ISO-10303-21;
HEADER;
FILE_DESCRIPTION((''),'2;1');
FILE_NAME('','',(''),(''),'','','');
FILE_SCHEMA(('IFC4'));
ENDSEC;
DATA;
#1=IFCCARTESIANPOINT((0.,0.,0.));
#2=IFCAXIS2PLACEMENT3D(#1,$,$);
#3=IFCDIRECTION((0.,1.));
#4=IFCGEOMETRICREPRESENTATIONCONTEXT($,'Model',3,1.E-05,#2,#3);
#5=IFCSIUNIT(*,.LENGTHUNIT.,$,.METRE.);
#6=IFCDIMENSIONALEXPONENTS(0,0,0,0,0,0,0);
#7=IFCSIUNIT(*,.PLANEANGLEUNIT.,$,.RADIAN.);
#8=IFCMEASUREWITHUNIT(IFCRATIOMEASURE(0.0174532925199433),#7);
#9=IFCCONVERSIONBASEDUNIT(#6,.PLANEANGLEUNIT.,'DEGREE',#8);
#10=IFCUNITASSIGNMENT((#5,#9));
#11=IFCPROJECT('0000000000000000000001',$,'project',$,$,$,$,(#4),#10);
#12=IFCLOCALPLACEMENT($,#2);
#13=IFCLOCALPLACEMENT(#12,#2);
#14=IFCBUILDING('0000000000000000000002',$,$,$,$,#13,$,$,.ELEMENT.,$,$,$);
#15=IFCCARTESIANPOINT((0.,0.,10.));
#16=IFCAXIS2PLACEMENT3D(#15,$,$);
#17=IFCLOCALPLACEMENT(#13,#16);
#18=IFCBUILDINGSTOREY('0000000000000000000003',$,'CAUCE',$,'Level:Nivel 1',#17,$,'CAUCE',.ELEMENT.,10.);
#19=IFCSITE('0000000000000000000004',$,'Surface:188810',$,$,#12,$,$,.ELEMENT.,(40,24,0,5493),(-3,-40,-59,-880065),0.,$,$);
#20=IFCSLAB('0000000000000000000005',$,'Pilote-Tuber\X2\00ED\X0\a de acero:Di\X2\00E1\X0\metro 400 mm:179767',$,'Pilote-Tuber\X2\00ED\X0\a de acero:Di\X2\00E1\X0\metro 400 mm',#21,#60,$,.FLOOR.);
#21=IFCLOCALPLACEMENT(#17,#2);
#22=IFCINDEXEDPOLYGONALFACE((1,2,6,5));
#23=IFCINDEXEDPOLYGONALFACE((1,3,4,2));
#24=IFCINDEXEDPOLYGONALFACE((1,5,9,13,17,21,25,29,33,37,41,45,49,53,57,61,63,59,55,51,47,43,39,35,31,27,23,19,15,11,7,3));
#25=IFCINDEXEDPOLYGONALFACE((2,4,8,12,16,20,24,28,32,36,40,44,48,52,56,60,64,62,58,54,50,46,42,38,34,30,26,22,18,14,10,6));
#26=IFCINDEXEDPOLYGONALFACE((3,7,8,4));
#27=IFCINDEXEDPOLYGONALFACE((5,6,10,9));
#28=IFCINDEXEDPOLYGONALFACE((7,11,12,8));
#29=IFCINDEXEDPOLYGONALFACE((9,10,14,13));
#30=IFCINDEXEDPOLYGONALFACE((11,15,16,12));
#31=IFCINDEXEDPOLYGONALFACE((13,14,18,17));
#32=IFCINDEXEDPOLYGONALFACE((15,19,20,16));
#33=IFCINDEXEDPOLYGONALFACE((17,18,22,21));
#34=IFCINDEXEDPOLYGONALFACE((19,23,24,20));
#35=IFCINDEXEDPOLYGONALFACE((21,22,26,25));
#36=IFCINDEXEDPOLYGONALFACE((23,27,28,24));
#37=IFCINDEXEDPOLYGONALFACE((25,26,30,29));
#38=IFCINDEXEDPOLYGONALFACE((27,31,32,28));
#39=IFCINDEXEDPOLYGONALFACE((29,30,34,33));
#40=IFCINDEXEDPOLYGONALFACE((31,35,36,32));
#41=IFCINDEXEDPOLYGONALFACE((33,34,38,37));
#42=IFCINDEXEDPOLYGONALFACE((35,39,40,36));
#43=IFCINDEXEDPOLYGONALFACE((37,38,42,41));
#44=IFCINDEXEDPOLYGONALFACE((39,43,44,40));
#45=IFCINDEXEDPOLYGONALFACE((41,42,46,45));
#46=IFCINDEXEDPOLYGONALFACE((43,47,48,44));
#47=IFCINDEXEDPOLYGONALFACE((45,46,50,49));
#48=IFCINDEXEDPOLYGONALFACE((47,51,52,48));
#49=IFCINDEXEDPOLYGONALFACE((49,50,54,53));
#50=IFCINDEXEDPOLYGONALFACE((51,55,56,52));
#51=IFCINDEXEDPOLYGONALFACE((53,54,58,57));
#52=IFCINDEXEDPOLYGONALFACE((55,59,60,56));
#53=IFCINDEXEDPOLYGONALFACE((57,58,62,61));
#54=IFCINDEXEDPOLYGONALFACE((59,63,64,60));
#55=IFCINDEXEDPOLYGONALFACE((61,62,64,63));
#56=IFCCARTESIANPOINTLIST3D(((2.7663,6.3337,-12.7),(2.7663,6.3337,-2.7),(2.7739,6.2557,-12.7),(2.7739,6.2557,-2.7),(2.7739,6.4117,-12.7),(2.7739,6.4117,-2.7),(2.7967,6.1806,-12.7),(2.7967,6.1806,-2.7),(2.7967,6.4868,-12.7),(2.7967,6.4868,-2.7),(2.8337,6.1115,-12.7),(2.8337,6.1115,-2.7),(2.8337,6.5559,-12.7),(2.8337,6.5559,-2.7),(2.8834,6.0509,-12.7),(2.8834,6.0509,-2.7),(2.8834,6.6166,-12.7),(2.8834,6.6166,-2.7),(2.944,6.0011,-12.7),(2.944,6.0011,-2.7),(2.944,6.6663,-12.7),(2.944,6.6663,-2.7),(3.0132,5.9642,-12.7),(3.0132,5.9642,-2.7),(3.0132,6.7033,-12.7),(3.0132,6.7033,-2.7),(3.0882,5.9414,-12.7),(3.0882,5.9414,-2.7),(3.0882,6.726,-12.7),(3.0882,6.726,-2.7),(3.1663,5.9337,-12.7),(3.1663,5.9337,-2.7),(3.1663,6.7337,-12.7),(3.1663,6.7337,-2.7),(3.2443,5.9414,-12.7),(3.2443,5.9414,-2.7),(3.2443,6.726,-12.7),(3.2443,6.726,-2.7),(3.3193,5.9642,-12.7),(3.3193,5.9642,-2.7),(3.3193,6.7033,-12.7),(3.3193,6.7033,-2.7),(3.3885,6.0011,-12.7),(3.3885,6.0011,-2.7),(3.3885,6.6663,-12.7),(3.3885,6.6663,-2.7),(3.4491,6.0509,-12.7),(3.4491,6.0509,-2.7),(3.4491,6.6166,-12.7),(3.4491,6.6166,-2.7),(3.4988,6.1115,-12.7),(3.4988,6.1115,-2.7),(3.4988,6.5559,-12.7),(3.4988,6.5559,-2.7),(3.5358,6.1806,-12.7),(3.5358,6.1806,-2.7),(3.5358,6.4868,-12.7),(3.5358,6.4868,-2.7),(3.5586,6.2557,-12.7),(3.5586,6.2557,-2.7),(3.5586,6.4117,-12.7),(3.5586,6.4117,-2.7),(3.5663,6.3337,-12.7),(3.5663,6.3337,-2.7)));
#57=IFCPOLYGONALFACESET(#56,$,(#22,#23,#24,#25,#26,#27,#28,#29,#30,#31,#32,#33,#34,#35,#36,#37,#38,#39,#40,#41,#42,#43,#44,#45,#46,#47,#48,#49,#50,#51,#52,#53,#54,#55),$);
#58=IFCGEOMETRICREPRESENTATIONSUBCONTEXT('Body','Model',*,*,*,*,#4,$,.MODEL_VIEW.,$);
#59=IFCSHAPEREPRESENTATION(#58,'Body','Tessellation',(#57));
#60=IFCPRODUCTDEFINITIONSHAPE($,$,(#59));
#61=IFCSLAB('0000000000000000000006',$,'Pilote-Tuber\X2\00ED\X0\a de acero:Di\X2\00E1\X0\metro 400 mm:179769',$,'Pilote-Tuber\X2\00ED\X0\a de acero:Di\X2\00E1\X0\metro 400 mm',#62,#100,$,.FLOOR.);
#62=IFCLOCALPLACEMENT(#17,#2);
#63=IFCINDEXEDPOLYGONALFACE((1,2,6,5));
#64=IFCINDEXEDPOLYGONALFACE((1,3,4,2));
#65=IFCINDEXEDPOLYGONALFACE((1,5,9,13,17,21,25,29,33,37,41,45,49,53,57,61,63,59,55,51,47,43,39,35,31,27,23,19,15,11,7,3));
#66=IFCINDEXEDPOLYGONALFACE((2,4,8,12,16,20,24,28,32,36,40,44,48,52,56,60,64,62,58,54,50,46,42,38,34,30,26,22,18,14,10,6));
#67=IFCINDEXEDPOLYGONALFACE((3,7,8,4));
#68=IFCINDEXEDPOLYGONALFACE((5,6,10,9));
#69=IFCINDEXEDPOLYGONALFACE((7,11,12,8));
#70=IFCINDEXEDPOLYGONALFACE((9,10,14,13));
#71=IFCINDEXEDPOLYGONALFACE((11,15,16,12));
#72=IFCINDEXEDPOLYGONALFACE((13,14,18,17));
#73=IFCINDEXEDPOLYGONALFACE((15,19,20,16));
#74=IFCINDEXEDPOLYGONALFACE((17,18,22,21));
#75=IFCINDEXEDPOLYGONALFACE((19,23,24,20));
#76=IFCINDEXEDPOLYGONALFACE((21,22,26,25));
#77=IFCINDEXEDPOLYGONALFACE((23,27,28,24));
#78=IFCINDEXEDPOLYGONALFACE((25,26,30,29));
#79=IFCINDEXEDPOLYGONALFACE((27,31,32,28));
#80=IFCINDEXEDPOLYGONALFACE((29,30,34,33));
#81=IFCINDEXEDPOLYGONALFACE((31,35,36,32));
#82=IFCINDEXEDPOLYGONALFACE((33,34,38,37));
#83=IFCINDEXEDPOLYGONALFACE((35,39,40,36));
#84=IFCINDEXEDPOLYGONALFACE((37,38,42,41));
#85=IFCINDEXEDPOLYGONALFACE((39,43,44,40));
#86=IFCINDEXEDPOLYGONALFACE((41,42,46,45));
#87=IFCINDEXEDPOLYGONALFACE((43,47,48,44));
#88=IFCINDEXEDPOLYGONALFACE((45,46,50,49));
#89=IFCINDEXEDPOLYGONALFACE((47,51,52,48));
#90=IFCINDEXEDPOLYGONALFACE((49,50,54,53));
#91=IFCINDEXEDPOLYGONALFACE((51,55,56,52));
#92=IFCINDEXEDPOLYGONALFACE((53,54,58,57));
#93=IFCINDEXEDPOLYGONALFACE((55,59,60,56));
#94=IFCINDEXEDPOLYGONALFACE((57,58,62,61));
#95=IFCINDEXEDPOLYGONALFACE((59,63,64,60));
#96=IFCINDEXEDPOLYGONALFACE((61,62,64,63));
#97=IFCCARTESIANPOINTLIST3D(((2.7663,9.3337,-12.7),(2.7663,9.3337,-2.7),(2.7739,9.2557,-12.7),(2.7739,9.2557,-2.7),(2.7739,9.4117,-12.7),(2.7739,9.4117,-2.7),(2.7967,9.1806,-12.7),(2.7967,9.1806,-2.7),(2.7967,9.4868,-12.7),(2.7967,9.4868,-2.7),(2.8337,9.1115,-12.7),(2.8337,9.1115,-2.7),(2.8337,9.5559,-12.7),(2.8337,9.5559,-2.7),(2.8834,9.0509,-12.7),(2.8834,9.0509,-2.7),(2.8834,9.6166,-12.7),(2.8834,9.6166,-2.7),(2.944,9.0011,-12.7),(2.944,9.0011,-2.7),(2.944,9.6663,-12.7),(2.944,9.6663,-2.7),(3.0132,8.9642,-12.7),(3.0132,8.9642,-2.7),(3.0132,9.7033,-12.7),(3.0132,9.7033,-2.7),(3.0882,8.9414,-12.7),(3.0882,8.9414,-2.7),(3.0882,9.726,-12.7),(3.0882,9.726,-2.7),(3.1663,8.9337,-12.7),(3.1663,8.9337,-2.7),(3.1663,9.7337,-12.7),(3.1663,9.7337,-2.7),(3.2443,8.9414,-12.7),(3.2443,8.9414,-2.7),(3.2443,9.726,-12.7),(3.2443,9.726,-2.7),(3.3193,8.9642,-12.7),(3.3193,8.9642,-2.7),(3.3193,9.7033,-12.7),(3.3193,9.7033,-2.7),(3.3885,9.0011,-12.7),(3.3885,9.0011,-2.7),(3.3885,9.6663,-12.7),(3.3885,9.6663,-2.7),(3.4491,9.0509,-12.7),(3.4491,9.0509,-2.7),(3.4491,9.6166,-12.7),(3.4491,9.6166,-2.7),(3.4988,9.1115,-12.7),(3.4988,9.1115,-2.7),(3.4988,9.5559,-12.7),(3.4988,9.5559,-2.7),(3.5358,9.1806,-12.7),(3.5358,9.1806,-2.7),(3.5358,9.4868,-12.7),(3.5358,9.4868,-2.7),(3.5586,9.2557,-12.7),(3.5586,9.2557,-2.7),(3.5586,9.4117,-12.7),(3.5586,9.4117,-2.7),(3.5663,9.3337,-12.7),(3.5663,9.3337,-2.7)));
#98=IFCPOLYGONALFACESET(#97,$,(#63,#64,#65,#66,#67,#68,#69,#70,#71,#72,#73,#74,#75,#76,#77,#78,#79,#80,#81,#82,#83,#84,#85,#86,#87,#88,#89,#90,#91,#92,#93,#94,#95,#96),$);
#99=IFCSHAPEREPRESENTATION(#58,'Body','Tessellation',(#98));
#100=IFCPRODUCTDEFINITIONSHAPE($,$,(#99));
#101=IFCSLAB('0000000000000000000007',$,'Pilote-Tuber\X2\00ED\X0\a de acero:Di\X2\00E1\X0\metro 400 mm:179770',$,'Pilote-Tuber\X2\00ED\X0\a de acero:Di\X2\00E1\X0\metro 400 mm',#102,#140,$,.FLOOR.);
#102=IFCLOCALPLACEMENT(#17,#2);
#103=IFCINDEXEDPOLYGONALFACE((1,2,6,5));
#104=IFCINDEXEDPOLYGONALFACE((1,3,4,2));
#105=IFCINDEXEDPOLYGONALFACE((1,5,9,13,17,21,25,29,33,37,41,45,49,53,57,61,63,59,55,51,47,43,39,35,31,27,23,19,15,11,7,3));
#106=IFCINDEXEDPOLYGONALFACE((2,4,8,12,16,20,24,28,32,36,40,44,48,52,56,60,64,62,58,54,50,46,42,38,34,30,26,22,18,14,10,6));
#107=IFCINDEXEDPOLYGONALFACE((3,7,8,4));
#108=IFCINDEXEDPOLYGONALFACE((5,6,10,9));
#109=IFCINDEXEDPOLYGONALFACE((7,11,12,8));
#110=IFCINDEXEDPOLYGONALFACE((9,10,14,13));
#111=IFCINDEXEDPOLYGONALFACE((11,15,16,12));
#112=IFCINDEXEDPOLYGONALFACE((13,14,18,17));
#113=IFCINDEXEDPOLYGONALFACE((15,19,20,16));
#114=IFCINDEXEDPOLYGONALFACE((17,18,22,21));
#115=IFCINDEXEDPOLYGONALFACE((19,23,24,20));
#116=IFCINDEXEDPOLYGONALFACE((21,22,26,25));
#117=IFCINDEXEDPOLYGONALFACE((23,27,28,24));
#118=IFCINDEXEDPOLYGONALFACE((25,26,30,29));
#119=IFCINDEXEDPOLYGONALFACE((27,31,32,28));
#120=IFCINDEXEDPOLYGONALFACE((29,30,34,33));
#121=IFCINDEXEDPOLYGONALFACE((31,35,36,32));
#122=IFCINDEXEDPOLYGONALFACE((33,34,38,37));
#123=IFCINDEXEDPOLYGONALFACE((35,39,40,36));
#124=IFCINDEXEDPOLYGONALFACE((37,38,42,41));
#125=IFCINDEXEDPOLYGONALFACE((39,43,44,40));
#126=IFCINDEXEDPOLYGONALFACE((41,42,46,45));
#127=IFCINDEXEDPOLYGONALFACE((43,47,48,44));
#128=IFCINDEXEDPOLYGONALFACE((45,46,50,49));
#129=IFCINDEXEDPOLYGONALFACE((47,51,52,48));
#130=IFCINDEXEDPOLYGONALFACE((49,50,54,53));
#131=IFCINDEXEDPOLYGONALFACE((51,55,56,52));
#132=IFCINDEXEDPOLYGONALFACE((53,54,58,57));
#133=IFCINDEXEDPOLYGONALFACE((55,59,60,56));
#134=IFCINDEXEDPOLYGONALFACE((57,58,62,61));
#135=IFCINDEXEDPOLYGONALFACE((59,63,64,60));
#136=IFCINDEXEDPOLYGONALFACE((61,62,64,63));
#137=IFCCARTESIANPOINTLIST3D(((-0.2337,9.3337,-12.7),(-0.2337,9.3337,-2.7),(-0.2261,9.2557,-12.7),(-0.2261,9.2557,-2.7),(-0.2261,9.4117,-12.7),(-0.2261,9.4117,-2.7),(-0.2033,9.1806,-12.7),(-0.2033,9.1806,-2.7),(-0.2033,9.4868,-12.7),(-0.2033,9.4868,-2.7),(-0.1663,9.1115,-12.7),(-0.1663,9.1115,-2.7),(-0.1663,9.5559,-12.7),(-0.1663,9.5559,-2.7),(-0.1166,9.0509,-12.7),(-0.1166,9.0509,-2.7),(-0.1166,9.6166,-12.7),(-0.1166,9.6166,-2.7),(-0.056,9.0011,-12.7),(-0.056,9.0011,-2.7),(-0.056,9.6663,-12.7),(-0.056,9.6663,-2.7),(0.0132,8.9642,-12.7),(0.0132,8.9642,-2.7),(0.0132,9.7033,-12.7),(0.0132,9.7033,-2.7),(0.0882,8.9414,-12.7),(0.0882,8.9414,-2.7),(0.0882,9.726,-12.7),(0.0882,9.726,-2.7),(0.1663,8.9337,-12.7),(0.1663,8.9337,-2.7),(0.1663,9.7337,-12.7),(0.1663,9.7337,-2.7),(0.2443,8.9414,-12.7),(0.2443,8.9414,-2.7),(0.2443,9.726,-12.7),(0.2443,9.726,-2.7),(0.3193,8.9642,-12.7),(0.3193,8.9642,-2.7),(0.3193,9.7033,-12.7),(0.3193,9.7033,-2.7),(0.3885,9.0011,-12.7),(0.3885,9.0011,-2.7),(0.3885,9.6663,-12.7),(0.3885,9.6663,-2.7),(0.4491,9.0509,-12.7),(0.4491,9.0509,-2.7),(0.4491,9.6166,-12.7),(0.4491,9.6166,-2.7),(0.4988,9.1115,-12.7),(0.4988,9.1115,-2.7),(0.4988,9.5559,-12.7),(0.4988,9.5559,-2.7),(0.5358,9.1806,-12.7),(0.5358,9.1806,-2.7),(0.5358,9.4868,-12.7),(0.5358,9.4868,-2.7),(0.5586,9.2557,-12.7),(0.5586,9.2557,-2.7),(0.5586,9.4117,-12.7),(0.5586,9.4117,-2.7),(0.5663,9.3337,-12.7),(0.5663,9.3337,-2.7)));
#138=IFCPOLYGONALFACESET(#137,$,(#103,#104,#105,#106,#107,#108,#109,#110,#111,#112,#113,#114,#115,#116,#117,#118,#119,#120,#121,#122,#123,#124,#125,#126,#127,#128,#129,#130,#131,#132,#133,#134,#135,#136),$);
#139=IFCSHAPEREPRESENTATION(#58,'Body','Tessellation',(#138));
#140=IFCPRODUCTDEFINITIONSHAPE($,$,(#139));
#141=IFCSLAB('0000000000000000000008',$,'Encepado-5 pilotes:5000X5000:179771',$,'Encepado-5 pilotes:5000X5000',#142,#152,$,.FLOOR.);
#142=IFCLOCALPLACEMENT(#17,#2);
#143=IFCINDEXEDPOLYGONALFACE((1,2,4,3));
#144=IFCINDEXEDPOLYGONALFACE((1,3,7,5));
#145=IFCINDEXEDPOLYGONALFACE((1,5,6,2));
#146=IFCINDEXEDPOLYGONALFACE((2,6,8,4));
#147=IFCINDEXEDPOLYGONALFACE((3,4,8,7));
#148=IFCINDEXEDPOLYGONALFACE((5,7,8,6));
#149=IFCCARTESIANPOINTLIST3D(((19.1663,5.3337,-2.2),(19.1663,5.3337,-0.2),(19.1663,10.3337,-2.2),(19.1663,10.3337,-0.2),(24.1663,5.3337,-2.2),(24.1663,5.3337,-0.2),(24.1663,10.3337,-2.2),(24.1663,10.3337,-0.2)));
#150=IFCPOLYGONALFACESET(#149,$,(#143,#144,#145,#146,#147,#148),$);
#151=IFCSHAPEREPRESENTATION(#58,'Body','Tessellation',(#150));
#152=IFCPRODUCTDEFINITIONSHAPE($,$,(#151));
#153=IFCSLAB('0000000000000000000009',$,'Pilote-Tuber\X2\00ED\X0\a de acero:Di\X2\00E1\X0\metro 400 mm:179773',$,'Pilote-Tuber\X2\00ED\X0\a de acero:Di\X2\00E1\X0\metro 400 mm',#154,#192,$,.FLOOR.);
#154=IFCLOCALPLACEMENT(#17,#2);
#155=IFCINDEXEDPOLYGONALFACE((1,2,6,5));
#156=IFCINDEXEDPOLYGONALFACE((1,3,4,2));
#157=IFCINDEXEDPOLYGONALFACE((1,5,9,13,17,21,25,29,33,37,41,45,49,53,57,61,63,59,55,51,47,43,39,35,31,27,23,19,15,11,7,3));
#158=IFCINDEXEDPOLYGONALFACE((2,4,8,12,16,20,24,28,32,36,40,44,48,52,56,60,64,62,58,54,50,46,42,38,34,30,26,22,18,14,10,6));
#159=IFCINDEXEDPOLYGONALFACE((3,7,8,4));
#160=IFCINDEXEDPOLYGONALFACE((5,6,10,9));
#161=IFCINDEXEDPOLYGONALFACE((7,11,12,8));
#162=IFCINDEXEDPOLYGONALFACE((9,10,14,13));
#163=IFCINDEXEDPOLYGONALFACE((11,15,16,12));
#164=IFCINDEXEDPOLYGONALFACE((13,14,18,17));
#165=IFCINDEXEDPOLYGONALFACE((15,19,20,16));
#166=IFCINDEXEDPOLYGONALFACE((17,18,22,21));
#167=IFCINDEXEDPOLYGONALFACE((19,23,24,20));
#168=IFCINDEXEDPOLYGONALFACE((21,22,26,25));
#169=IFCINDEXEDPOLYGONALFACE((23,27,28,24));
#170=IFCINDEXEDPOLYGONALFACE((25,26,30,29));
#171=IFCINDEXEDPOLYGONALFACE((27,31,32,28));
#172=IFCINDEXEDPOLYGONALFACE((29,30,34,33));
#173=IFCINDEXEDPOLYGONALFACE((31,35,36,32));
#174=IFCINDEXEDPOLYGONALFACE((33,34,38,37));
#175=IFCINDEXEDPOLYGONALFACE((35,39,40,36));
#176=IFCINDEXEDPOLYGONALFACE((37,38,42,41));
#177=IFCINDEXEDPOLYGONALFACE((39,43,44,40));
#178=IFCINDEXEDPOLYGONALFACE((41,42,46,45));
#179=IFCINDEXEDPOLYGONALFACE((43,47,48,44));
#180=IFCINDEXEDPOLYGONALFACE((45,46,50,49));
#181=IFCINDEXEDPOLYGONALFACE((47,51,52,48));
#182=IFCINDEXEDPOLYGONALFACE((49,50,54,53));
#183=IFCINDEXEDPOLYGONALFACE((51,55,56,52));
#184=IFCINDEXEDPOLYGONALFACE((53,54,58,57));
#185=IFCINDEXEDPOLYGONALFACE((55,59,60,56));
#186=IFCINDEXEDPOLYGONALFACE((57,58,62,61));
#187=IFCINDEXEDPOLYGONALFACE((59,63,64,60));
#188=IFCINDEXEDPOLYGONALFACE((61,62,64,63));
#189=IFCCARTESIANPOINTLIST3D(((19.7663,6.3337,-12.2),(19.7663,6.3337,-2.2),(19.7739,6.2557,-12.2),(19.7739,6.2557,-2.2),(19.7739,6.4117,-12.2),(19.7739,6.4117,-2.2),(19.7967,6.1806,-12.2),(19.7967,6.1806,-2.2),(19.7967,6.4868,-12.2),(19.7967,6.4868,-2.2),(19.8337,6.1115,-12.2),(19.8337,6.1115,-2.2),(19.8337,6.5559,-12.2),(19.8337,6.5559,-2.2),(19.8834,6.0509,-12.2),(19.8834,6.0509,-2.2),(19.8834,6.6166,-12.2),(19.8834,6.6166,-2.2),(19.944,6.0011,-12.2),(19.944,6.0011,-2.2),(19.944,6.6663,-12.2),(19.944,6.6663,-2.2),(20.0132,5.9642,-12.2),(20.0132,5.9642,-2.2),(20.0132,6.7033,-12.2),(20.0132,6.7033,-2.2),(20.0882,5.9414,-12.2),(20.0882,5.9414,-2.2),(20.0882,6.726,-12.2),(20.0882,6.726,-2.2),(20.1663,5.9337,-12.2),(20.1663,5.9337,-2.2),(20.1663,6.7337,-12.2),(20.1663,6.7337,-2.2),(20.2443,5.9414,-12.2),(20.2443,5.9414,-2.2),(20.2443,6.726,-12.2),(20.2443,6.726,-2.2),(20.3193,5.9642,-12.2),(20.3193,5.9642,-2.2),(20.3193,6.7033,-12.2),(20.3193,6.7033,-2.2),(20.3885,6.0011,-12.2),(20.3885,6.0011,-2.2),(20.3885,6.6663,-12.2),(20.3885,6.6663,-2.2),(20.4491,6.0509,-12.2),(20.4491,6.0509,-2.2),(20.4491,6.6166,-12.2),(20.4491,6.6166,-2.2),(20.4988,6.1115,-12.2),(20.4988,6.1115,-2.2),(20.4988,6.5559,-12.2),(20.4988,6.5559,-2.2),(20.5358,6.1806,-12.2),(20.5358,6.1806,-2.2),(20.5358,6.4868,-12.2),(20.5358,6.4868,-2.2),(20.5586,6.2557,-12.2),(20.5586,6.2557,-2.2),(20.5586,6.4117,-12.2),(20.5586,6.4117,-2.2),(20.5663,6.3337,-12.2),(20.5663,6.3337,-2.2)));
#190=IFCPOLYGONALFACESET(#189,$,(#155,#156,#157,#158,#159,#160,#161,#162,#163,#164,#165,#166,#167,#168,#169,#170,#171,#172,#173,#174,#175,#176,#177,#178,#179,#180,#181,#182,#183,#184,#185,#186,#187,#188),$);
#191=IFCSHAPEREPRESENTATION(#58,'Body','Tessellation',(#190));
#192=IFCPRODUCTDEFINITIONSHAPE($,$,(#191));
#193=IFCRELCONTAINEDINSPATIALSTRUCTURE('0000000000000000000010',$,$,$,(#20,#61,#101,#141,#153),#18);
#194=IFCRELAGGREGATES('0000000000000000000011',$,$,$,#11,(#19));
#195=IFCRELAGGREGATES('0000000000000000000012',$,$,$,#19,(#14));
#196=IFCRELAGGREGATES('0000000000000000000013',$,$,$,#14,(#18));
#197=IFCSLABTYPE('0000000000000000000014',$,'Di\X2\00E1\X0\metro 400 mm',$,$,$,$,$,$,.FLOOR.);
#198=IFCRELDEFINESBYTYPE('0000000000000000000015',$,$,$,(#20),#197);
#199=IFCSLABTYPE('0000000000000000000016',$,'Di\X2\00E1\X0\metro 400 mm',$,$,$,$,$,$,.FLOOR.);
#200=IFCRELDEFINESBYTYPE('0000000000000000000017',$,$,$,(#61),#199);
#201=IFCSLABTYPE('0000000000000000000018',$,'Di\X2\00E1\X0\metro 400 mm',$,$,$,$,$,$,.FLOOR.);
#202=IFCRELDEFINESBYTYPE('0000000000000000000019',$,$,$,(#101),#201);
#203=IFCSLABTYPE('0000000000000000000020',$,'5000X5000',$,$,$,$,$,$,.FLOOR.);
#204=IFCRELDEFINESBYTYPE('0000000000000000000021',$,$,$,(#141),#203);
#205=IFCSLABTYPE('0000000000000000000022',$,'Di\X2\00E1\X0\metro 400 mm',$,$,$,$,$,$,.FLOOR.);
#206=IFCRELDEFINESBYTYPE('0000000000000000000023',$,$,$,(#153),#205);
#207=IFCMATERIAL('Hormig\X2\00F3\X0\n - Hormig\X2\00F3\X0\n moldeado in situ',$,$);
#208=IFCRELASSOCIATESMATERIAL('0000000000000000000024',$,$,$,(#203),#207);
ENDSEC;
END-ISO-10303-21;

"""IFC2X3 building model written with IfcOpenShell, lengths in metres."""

from ifc_helpers import new_model, entity, si_unit, converted_unit, direction, frame, origin, origin_2d_with_axis, place, context, subcontext, project, spatial, rectangle, circle, extrude, material, type_object, element, save


model = new_model("IFC2X3")

# Units and contexts
model_context = context("Model", 3, precision=1e-05, world=origin(), true_north=direction((0.0, 1.0)))
body_context = subcontext(model_context, "Body", "Model", "MODEL_VIEW")
ifc_project = project(units=[si_unit("LENGTHUNIT", "METRE"), converted_unit("PLANEANGLEUNIT", "DEGREE", entity("IfcRatioMeasure", 0.0174532925199433), si_unit("PLANEANGLEUNIT", "RADIAN"), dimensions=[0, 0, 0, 0, 0, 0, 0])], contexts=[model_context])

# Site, building, storey
site_placement = place(None, origin())
site = spatial("IfcSite", under=ifc_project, at=site_placement, Name="Surface:188810", CompositionType="ELEMENT", RefLatitude=(40, 24, 0, 5493), RefLongitude=(-3, -40, -59, -880065), RefElevation=0.0)
building_placement = place(site_placement, origin())
building = spatial("IfcBuilding", under=site, at=building_placement, CompositionType="ELEMENT")
storey_placement = place(building_placement, frame((0.0, 0.0, 10.0)))
storey = spatial("IfcBuildingStorey", under=building, at=storey_placement, Name="CAUCE", ObjectType="Level:Nivel 1", LongName="CAUCE", CompositionType="ELEMENT", Elevation=10.0)

# Slabs
ifc_material = material(Name="Hormigón - Hormigón moldeado in situ")
slab_type_1 = type_object("IfcSlabType", Name="Diámetro 400 mm", PredefinedType="FLOOR")
slab_1_placement = place(storey_placement, origin())
element("IfcSlab", 1, at=slab_1_placement, inside=storey, type_object=slab_type_1, Name="Pilote-Tubería de acero:Diámetro 400 mm:179767", ObjectType="Pilote-Tubería de acero:Diámetro 400 mm", PredefinedType="FLOOR", context=body_context, shape_type="SweptSolid", body=[
    extrude(circle(Radius=0.4, at=origin_2d_with_axis()), frame((3.1663, 6.3337, -12.7)), (0.0, 0.0, 1.0), 10.0),
])
slab_type_2 = type_object("IfcSlabType", Name="Diámetro 400 mm", PredefinedType="FLOOR")
slab_2_placement = place(storey_placement, origin())
element("IfcSlab", 2, at=slab_2_placement, inside=storey, type_object=slab_type_2, Name="Pilote-Tubería de acero:Diámetro 400 mm:179769", ObjectType="Pilote-Tubería de acero:Diámetro 400 mm", PredefinedType="FLOOR", context=body_context, shape_type="SweptSolid", body=[
    extrude(circle(Radius=0.4, at=origin_2d_with_axis()), frame((3.1663, 9.3337, -12.7)), (0.0, 0.0, 1.0), 10.0),
])
slab_type_3 = type_object("IfcSlabType", Name="Diámetro 400 mm", PredefinedType="FLOOR")
slab_3_placement = place(storey_placement, origin())
element("IfcSlab", 3, at=slab_3_placement, inside=storey, type_object=slab_type_3, Name="Pilote-Tubería de acero:Diámetro 400 mm:179770", ObjectType="Pilote-Tubería de acero:Diámetro 400 mm", PredefinedType="FLOOR", context=body_context, shape_type="SweptSolid", body=[
    extrude(circle(Radius=0.4, at=origin_2d_with_axis()), frame((0.1663, 9.3337, -12.7)), (0.0, 0.0, 1.0), 10.0),
])
slab_type_4 = type_object("IfcSlabType", Name="5000X5000", PredefinedType="FLOOR", material=ifc_material)
slab_4_placement = place(storey_placement, origin())
element("IfcSlab", 4, at=slab_4_placement, inside=storey, type_object=slab_type_4, Name="Encepado-5 pilotes:5000X5000:179771", ObjectType="Encepado-5 pilotes:5000X5000", PredefinedType="FLOOR", context=body_context, shape_type="SweptSolid", body=[
    extrude(rectangle(XDim=5.0, YDim=5.0, at=origin_2d_with_axis()), frame((21.6663, 7.8337, -2.2), z_axis=(0.0, 0.0, 1.0), x_axis=(-1.0, 0.0, 0.0)), (0.0, 0.0, 1.0), 2.0),
])
slab_type_5 = type_object("IfcSlabType", Name="Diámetro 400 mm", PredefinedType="FLOOR")
slab_5_placement = place(storey_placement, origin())
element("IfcSlab", 5, at=slab_5_placement, inside=storey, type_object=slab_type_5, Name="Pilote-Tubería de acero:Diámetro 400 mm:179773", ObjectType="Pilote-Tubería de acero:Diámetro 400 mm", PredefinedType="FLOOR", context=body_context, shape_type="SweptSolid", body=[
    extrude(circle(Radius=0.4, at=origin_2d_with_axis()), frame((20.1663, 6.3337, -12.2)), (0.0, 0.0, 1.0), 10.0),
])

save(model, "model.ifc")
